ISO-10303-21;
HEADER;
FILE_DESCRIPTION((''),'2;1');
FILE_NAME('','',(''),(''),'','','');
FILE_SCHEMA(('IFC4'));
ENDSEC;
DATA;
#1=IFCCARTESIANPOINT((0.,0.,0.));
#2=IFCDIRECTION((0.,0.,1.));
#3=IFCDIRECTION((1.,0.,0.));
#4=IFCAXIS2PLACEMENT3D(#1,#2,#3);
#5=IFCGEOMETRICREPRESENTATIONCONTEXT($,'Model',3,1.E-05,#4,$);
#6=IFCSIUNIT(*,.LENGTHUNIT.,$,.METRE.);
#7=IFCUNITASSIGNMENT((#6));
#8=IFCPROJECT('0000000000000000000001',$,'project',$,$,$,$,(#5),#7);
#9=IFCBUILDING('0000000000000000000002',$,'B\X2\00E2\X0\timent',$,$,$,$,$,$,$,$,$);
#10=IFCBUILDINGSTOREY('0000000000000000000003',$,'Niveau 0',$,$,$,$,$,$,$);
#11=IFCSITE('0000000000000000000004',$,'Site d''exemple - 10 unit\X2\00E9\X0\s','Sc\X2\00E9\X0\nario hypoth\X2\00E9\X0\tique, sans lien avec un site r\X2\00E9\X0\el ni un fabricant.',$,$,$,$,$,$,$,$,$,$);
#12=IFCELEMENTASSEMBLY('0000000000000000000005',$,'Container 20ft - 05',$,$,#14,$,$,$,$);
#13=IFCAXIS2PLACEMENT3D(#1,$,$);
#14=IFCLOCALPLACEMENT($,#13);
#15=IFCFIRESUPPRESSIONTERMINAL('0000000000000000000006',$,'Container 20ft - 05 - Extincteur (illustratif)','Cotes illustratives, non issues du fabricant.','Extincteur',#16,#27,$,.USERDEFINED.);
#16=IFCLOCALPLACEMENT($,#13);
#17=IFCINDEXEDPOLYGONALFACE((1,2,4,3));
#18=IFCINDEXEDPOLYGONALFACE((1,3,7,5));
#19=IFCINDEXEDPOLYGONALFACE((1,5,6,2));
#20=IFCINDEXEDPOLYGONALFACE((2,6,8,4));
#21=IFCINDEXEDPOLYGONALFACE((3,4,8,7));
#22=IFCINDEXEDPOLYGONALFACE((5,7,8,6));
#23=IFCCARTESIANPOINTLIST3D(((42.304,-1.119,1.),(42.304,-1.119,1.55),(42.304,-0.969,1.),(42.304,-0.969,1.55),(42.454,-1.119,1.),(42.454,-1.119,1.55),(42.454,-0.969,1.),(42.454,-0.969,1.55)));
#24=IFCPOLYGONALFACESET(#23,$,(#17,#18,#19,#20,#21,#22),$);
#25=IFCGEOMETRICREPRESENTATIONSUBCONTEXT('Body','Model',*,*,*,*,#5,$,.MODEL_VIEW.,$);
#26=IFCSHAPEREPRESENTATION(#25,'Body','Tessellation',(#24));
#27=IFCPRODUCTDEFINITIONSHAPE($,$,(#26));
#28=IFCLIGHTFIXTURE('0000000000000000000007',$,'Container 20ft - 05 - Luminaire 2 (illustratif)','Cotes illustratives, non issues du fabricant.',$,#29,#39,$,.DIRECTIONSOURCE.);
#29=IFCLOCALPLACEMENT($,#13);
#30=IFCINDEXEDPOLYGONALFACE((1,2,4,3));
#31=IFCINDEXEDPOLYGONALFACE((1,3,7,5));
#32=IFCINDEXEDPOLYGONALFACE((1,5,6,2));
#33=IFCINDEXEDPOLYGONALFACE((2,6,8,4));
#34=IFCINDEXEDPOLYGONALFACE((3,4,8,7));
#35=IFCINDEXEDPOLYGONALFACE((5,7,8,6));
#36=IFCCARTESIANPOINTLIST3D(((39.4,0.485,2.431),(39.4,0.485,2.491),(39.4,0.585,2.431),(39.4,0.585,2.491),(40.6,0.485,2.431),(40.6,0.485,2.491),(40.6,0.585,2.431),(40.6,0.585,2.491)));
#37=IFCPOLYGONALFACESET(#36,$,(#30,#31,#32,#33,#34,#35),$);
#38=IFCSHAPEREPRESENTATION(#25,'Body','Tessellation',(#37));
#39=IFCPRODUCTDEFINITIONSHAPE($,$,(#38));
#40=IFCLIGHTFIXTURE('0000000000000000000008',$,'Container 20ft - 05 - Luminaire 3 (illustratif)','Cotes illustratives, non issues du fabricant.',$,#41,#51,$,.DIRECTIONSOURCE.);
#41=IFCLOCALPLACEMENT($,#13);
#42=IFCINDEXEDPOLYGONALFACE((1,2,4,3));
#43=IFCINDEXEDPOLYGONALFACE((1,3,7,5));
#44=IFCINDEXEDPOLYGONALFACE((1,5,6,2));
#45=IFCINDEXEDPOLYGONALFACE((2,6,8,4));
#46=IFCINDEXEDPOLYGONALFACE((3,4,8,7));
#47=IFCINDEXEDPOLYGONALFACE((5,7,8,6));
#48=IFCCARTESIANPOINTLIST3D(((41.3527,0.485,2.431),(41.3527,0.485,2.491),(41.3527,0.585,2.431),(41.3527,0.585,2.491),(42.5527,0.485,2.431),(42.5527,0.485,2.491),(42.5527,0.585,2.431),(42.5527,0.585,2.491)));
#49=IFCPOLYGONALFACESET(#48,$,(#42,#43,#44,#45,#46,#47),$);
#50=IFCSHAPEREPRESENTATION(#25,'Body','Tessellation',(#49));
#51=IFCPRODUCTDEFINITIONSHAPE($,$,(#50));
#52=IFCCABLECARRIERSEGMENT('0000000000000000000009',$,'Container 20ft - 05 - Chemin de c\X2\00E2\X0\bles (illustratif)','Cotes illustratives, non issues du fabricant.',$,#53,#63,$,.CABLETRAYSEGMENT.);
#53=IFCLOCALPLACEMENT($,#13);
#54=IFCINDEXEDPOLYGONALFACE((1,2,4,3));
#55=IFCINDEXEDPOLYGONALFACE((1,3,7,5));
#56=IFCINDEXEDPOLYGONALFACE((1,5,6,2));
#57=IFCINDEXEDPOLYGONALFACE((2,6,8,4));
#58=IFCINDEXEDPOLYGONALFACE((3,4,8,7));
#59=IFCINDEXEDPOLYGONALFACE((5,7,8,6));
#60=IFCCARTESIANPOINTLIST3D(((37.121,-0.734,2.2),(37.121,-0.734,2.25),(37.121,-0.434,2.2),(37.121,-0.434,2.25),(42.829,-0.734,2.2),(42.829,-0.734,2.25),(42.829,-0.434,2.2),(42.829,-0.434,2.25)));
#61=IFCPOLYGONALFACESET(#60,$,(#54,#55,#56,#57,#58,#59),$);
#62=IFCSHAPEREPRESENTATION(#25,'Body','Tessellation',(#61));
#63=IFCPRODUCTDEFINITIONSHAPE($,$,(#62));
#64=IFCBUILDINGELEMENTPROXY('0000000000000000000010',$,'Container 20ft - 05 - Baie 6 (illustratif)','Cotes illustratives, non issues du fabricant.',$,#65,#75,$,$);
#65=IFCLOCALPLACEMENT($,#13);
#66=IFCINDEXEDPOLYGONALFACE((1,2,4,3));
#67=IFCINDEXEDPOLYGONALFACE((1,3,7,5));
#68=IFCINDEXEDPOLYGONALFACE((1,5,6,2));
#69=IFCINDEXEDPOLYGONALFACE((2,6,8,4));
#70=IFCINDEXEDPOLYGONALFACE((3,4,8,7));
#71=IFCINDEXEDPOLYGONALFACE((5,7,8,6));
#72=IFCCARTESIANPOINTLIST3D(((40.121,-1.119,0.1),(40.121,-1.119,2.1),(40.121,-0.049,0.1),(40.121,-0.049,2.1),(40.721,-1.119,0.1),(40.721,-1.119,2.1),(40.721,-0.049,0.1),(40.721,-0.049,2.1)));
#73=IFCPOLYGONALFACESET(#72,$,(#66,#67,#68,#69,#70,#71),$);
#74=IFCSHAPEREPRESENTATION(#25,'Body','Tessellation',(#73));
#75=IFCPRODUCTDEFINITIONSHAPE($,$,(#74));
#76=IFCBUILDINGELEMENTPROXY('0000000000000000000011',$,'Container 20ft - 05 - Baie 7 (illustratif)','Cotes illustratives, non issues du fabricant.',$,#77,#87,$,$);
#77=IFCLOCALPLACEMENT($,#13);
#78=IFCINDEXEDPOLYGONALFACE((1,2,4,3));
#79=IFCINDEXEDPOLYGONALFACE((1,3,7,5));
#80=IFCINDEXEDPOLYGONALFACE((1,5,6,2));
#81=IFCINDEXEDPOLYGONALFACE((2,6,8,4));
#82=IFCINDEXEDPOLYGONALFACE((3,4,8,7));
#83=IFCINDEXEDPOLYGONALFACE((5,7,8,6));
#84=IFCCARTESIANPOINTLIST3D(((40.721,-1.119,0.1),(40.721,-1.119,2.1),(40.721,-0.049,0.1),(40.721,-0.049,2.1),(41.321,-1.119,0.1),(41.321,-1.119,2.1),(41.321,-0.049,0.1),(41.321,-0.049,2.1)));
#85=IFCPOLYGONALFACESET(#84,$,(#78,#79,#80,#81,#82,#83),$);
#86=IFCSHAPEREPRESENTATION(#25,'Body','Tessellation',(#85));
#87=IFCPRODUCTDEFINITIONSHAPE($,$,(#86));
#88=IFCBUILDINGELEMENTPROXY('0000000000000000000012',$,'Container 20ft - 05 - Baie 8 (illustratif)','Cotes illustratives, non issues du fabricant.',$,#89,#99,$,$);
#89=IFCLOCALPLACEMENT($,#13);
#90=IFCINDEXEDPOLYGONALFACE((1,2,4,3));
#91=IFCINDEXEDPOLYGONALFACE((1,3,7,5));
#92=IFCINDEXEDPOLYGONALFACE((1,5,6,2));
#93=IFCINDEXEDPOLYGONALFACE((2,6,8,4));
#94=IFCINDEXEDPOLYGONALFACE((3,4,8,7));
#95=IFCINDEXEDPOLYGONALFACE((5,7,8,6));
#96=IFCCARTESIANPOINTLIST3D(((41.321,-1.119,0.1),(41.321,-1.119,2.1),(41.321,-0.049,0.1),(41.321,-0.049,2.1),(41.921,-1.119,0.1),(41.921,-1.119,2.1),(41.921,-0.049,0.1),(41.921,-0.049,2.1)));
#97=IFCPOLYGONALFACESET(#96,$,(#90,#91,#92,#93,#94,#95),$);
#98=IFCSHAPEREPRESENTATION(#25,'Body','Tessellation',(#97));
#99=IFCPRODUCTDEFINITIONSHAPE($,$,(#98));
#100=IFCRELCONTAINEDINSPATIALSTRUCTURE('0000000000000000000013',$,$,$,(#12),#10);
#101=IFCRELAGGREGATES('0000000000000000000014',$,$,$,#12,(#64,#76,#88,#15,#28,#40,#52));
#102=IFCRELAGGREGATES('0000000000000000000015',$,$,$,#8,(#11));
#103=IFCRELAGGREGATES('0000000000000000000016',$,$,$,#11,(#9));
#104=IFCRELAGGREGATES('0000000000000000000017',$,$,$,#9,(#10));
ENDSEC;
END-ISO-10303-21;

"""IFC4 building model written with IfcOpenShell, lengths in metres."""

from ifc_helpers import new_model, si_unit, frame, origin_with_axes, place, context, subcontext, project, spatial, rectangle, extrude, element, aggregate, save


model = new_model("IFC4")

# Units and contexts
model_context = context("Model", 3, precision=1e-05, world=origin_with_axes())
body_context = subcontext(model_context, "Body", "Model", "MODEL_VIEW")
ifc_project = project(units=[si_unit("LENGTHUNIT", "METRE")], contexts=[model_context])

# Site, building, storey
site = spatial("IfcSite", under=ifc_project, Name="Site d'exemple - 10 unités", Description="Scénario hypothétique, sans lien avec un site réel ni un fabricant.")
building = spatial("IfcBuilding", under=site, Name="Bâtiment")
storey = spatial("IfcBuildingStorey", under=building, Name="Niveau 0")

# Element assembly, fire suppression terminal, light fixtures, cable carrier segment, building element proxies
assembly = element("IfcElementAssembly", 1, inside=storey, Name="Container 20ft - 05")
fire_suppression_terminal_placement = place(None, frame((42.379, -1.044, 1.0), z_axis=(0.0, 0.0, 1.0), x_axis=(1.0, 0.0, 0.0)))
fire_suppression_terminal = element("IfcFireSuppressionTerminal", 2, at=fire_suppression_terminal_placement, Name="Container 20ft - 05 - Extincteur (illustratif)", Description="Cotes illustratives, non issues du fabricant.", ObjectType="Extincteur", PredefinedType="USERDEFINED", context=body_context, shape_type="SweptSolid", body=[
    extrude(rectangle(XDim=0.15, YDim=0.15), origin_with_axes(), (0.0, 0.0, 1.0), 0.55),
])
light_fixture_1_placement = place(None, frame((40.0, 0.535, 2.431), z_axis=(0.0, 0.0, 1.0), x_axis=(1.0, 0.0, 0.0)))
light_fixture_1 = element("IfcLightFixture", 3, at=light_fixture_1_placement, Name="Container 20ft - 05 - Luminaire 2 (illustratif)", Description="Cotes illustratives, non issues du fabricant.", PredefinedType="DIRECTIONSOURCE", context=body_context, shape_type="SweptSolid", body=[
    extrude(rectangle(XDim=1.2, YDim=0.1), origin_with_axes(), (0.0, 0.0, 1.0), 0.06),
])
light_fixture_2_placement = place(None, frame((41.9527, 0.535, 2.431), z_axis=(0.0, 0.0, 1.0), x_axis=(1.0, 0.0, 0.0)))
light_fixture_2 = element("IfcLightFixture", 4, at=light_fixture_2_placement, Name="Container 20ft - 05 - Luminaire 3 (illustratif)", Description="Cotes illustratives, non issues du fabricant.", PredefinedType="DIRECTIONSOURCE", context=body_context, shape_type="SweptSolid", body=[
    extrude(rectangle(XDim=1.2, YDim=0.1), origin_with_axes(), (0.0, 0.0, 1.0), 0.06),
])
cable_carrier_segment_placement = place(None, frame((39.975, -0.584, 2.2), z_axis=(0.0, 0.0, 1.0), x_axis=(1.0, 0.0, 0.0)))
cable_carrier_segment = element("IfcCableCarrierSegment", 5, at=cable_carrier_segment_placement, Name="Container 20ft - 05 - Chemin de câbles (illustratif)", Description="Cotes illustratives, non issues du fabricant.", PredefinedType="CABLETRAYSEGMENT", context=body_context, shape_type="SweptSolid", body=[
    extrude(rectangle(XDim=5.708, YDim=0.3), origin_with_axes(), (0.0, 0.0, 1.0), 0.05),
])
proxy_1_placement = place(None, frame((40.421, -0.584, 0.1), z_axis=(0.0, 0.0, 1.0), x_axis=(1.0, 0.0, 0.0)))
proxy_1 = element("IfcBuildingElementProxy", 6, at=proxy_1_placement, Name="Container 20ft - 05 - Baie 6 (illustratif)", Description="Cotes illustratives, non issues du fabricant.", context=body_context, shape_type="SweptSolid", body=[
    extrude(rectangle(XDim=0.6, YDim=1.07), origin_with_axes(), (0.0, 0.0, 1.0), 2.0),
])
proxy_2_placement = place(None, frame((41.021, -0.584, 0.1), z_axis=(0.0, 0.0, 1.0), x_axis=(1.0, 0.0, 0.0)))
proxy_2 = element("IfcBuildingElementProxy", 7, at=proxy_2_placement, Name="Container 20ft - 05 - Baie 7 (illustratif)", Description="Cotes illustratives, non issues du fabricant.", context=body_context, shape_type="SweptSolid", body=[
    extrude(rectangle(XDim=0.6, YDim=1.07), origin_with_axes(), (0.0, 0.0, 1.0), 2.0),
])
proxy_3_placement = place(None, frame((41.621, -0.584, 0.1), z_axis=(0.0, 0.0, 1.0), x_axis=(1.0, 0.0, 0.0)))
proxy_3 = element("IfcBuildingElementProxy", 8, at=proxy_3_placement, Name="Container 20ft - 05 - Baie 8 (illustratif)", Description="Cotes illustratives, non issues du fabricant.", context=body_context, shape_type="SweptSolid", body=[
    extrude(rectangle(XDim=0.6, YDim=1.07), origin_with_axes(), (0.0, 0.0, 1.0), 2.0),
])
aggregate(assembly, [proxy_1, proxy_2, proxy_3, fire_suppression_terminal, light_fixture_1, light_fixture_2, cable_carrier_segment])

save(model, "model.ifc")
